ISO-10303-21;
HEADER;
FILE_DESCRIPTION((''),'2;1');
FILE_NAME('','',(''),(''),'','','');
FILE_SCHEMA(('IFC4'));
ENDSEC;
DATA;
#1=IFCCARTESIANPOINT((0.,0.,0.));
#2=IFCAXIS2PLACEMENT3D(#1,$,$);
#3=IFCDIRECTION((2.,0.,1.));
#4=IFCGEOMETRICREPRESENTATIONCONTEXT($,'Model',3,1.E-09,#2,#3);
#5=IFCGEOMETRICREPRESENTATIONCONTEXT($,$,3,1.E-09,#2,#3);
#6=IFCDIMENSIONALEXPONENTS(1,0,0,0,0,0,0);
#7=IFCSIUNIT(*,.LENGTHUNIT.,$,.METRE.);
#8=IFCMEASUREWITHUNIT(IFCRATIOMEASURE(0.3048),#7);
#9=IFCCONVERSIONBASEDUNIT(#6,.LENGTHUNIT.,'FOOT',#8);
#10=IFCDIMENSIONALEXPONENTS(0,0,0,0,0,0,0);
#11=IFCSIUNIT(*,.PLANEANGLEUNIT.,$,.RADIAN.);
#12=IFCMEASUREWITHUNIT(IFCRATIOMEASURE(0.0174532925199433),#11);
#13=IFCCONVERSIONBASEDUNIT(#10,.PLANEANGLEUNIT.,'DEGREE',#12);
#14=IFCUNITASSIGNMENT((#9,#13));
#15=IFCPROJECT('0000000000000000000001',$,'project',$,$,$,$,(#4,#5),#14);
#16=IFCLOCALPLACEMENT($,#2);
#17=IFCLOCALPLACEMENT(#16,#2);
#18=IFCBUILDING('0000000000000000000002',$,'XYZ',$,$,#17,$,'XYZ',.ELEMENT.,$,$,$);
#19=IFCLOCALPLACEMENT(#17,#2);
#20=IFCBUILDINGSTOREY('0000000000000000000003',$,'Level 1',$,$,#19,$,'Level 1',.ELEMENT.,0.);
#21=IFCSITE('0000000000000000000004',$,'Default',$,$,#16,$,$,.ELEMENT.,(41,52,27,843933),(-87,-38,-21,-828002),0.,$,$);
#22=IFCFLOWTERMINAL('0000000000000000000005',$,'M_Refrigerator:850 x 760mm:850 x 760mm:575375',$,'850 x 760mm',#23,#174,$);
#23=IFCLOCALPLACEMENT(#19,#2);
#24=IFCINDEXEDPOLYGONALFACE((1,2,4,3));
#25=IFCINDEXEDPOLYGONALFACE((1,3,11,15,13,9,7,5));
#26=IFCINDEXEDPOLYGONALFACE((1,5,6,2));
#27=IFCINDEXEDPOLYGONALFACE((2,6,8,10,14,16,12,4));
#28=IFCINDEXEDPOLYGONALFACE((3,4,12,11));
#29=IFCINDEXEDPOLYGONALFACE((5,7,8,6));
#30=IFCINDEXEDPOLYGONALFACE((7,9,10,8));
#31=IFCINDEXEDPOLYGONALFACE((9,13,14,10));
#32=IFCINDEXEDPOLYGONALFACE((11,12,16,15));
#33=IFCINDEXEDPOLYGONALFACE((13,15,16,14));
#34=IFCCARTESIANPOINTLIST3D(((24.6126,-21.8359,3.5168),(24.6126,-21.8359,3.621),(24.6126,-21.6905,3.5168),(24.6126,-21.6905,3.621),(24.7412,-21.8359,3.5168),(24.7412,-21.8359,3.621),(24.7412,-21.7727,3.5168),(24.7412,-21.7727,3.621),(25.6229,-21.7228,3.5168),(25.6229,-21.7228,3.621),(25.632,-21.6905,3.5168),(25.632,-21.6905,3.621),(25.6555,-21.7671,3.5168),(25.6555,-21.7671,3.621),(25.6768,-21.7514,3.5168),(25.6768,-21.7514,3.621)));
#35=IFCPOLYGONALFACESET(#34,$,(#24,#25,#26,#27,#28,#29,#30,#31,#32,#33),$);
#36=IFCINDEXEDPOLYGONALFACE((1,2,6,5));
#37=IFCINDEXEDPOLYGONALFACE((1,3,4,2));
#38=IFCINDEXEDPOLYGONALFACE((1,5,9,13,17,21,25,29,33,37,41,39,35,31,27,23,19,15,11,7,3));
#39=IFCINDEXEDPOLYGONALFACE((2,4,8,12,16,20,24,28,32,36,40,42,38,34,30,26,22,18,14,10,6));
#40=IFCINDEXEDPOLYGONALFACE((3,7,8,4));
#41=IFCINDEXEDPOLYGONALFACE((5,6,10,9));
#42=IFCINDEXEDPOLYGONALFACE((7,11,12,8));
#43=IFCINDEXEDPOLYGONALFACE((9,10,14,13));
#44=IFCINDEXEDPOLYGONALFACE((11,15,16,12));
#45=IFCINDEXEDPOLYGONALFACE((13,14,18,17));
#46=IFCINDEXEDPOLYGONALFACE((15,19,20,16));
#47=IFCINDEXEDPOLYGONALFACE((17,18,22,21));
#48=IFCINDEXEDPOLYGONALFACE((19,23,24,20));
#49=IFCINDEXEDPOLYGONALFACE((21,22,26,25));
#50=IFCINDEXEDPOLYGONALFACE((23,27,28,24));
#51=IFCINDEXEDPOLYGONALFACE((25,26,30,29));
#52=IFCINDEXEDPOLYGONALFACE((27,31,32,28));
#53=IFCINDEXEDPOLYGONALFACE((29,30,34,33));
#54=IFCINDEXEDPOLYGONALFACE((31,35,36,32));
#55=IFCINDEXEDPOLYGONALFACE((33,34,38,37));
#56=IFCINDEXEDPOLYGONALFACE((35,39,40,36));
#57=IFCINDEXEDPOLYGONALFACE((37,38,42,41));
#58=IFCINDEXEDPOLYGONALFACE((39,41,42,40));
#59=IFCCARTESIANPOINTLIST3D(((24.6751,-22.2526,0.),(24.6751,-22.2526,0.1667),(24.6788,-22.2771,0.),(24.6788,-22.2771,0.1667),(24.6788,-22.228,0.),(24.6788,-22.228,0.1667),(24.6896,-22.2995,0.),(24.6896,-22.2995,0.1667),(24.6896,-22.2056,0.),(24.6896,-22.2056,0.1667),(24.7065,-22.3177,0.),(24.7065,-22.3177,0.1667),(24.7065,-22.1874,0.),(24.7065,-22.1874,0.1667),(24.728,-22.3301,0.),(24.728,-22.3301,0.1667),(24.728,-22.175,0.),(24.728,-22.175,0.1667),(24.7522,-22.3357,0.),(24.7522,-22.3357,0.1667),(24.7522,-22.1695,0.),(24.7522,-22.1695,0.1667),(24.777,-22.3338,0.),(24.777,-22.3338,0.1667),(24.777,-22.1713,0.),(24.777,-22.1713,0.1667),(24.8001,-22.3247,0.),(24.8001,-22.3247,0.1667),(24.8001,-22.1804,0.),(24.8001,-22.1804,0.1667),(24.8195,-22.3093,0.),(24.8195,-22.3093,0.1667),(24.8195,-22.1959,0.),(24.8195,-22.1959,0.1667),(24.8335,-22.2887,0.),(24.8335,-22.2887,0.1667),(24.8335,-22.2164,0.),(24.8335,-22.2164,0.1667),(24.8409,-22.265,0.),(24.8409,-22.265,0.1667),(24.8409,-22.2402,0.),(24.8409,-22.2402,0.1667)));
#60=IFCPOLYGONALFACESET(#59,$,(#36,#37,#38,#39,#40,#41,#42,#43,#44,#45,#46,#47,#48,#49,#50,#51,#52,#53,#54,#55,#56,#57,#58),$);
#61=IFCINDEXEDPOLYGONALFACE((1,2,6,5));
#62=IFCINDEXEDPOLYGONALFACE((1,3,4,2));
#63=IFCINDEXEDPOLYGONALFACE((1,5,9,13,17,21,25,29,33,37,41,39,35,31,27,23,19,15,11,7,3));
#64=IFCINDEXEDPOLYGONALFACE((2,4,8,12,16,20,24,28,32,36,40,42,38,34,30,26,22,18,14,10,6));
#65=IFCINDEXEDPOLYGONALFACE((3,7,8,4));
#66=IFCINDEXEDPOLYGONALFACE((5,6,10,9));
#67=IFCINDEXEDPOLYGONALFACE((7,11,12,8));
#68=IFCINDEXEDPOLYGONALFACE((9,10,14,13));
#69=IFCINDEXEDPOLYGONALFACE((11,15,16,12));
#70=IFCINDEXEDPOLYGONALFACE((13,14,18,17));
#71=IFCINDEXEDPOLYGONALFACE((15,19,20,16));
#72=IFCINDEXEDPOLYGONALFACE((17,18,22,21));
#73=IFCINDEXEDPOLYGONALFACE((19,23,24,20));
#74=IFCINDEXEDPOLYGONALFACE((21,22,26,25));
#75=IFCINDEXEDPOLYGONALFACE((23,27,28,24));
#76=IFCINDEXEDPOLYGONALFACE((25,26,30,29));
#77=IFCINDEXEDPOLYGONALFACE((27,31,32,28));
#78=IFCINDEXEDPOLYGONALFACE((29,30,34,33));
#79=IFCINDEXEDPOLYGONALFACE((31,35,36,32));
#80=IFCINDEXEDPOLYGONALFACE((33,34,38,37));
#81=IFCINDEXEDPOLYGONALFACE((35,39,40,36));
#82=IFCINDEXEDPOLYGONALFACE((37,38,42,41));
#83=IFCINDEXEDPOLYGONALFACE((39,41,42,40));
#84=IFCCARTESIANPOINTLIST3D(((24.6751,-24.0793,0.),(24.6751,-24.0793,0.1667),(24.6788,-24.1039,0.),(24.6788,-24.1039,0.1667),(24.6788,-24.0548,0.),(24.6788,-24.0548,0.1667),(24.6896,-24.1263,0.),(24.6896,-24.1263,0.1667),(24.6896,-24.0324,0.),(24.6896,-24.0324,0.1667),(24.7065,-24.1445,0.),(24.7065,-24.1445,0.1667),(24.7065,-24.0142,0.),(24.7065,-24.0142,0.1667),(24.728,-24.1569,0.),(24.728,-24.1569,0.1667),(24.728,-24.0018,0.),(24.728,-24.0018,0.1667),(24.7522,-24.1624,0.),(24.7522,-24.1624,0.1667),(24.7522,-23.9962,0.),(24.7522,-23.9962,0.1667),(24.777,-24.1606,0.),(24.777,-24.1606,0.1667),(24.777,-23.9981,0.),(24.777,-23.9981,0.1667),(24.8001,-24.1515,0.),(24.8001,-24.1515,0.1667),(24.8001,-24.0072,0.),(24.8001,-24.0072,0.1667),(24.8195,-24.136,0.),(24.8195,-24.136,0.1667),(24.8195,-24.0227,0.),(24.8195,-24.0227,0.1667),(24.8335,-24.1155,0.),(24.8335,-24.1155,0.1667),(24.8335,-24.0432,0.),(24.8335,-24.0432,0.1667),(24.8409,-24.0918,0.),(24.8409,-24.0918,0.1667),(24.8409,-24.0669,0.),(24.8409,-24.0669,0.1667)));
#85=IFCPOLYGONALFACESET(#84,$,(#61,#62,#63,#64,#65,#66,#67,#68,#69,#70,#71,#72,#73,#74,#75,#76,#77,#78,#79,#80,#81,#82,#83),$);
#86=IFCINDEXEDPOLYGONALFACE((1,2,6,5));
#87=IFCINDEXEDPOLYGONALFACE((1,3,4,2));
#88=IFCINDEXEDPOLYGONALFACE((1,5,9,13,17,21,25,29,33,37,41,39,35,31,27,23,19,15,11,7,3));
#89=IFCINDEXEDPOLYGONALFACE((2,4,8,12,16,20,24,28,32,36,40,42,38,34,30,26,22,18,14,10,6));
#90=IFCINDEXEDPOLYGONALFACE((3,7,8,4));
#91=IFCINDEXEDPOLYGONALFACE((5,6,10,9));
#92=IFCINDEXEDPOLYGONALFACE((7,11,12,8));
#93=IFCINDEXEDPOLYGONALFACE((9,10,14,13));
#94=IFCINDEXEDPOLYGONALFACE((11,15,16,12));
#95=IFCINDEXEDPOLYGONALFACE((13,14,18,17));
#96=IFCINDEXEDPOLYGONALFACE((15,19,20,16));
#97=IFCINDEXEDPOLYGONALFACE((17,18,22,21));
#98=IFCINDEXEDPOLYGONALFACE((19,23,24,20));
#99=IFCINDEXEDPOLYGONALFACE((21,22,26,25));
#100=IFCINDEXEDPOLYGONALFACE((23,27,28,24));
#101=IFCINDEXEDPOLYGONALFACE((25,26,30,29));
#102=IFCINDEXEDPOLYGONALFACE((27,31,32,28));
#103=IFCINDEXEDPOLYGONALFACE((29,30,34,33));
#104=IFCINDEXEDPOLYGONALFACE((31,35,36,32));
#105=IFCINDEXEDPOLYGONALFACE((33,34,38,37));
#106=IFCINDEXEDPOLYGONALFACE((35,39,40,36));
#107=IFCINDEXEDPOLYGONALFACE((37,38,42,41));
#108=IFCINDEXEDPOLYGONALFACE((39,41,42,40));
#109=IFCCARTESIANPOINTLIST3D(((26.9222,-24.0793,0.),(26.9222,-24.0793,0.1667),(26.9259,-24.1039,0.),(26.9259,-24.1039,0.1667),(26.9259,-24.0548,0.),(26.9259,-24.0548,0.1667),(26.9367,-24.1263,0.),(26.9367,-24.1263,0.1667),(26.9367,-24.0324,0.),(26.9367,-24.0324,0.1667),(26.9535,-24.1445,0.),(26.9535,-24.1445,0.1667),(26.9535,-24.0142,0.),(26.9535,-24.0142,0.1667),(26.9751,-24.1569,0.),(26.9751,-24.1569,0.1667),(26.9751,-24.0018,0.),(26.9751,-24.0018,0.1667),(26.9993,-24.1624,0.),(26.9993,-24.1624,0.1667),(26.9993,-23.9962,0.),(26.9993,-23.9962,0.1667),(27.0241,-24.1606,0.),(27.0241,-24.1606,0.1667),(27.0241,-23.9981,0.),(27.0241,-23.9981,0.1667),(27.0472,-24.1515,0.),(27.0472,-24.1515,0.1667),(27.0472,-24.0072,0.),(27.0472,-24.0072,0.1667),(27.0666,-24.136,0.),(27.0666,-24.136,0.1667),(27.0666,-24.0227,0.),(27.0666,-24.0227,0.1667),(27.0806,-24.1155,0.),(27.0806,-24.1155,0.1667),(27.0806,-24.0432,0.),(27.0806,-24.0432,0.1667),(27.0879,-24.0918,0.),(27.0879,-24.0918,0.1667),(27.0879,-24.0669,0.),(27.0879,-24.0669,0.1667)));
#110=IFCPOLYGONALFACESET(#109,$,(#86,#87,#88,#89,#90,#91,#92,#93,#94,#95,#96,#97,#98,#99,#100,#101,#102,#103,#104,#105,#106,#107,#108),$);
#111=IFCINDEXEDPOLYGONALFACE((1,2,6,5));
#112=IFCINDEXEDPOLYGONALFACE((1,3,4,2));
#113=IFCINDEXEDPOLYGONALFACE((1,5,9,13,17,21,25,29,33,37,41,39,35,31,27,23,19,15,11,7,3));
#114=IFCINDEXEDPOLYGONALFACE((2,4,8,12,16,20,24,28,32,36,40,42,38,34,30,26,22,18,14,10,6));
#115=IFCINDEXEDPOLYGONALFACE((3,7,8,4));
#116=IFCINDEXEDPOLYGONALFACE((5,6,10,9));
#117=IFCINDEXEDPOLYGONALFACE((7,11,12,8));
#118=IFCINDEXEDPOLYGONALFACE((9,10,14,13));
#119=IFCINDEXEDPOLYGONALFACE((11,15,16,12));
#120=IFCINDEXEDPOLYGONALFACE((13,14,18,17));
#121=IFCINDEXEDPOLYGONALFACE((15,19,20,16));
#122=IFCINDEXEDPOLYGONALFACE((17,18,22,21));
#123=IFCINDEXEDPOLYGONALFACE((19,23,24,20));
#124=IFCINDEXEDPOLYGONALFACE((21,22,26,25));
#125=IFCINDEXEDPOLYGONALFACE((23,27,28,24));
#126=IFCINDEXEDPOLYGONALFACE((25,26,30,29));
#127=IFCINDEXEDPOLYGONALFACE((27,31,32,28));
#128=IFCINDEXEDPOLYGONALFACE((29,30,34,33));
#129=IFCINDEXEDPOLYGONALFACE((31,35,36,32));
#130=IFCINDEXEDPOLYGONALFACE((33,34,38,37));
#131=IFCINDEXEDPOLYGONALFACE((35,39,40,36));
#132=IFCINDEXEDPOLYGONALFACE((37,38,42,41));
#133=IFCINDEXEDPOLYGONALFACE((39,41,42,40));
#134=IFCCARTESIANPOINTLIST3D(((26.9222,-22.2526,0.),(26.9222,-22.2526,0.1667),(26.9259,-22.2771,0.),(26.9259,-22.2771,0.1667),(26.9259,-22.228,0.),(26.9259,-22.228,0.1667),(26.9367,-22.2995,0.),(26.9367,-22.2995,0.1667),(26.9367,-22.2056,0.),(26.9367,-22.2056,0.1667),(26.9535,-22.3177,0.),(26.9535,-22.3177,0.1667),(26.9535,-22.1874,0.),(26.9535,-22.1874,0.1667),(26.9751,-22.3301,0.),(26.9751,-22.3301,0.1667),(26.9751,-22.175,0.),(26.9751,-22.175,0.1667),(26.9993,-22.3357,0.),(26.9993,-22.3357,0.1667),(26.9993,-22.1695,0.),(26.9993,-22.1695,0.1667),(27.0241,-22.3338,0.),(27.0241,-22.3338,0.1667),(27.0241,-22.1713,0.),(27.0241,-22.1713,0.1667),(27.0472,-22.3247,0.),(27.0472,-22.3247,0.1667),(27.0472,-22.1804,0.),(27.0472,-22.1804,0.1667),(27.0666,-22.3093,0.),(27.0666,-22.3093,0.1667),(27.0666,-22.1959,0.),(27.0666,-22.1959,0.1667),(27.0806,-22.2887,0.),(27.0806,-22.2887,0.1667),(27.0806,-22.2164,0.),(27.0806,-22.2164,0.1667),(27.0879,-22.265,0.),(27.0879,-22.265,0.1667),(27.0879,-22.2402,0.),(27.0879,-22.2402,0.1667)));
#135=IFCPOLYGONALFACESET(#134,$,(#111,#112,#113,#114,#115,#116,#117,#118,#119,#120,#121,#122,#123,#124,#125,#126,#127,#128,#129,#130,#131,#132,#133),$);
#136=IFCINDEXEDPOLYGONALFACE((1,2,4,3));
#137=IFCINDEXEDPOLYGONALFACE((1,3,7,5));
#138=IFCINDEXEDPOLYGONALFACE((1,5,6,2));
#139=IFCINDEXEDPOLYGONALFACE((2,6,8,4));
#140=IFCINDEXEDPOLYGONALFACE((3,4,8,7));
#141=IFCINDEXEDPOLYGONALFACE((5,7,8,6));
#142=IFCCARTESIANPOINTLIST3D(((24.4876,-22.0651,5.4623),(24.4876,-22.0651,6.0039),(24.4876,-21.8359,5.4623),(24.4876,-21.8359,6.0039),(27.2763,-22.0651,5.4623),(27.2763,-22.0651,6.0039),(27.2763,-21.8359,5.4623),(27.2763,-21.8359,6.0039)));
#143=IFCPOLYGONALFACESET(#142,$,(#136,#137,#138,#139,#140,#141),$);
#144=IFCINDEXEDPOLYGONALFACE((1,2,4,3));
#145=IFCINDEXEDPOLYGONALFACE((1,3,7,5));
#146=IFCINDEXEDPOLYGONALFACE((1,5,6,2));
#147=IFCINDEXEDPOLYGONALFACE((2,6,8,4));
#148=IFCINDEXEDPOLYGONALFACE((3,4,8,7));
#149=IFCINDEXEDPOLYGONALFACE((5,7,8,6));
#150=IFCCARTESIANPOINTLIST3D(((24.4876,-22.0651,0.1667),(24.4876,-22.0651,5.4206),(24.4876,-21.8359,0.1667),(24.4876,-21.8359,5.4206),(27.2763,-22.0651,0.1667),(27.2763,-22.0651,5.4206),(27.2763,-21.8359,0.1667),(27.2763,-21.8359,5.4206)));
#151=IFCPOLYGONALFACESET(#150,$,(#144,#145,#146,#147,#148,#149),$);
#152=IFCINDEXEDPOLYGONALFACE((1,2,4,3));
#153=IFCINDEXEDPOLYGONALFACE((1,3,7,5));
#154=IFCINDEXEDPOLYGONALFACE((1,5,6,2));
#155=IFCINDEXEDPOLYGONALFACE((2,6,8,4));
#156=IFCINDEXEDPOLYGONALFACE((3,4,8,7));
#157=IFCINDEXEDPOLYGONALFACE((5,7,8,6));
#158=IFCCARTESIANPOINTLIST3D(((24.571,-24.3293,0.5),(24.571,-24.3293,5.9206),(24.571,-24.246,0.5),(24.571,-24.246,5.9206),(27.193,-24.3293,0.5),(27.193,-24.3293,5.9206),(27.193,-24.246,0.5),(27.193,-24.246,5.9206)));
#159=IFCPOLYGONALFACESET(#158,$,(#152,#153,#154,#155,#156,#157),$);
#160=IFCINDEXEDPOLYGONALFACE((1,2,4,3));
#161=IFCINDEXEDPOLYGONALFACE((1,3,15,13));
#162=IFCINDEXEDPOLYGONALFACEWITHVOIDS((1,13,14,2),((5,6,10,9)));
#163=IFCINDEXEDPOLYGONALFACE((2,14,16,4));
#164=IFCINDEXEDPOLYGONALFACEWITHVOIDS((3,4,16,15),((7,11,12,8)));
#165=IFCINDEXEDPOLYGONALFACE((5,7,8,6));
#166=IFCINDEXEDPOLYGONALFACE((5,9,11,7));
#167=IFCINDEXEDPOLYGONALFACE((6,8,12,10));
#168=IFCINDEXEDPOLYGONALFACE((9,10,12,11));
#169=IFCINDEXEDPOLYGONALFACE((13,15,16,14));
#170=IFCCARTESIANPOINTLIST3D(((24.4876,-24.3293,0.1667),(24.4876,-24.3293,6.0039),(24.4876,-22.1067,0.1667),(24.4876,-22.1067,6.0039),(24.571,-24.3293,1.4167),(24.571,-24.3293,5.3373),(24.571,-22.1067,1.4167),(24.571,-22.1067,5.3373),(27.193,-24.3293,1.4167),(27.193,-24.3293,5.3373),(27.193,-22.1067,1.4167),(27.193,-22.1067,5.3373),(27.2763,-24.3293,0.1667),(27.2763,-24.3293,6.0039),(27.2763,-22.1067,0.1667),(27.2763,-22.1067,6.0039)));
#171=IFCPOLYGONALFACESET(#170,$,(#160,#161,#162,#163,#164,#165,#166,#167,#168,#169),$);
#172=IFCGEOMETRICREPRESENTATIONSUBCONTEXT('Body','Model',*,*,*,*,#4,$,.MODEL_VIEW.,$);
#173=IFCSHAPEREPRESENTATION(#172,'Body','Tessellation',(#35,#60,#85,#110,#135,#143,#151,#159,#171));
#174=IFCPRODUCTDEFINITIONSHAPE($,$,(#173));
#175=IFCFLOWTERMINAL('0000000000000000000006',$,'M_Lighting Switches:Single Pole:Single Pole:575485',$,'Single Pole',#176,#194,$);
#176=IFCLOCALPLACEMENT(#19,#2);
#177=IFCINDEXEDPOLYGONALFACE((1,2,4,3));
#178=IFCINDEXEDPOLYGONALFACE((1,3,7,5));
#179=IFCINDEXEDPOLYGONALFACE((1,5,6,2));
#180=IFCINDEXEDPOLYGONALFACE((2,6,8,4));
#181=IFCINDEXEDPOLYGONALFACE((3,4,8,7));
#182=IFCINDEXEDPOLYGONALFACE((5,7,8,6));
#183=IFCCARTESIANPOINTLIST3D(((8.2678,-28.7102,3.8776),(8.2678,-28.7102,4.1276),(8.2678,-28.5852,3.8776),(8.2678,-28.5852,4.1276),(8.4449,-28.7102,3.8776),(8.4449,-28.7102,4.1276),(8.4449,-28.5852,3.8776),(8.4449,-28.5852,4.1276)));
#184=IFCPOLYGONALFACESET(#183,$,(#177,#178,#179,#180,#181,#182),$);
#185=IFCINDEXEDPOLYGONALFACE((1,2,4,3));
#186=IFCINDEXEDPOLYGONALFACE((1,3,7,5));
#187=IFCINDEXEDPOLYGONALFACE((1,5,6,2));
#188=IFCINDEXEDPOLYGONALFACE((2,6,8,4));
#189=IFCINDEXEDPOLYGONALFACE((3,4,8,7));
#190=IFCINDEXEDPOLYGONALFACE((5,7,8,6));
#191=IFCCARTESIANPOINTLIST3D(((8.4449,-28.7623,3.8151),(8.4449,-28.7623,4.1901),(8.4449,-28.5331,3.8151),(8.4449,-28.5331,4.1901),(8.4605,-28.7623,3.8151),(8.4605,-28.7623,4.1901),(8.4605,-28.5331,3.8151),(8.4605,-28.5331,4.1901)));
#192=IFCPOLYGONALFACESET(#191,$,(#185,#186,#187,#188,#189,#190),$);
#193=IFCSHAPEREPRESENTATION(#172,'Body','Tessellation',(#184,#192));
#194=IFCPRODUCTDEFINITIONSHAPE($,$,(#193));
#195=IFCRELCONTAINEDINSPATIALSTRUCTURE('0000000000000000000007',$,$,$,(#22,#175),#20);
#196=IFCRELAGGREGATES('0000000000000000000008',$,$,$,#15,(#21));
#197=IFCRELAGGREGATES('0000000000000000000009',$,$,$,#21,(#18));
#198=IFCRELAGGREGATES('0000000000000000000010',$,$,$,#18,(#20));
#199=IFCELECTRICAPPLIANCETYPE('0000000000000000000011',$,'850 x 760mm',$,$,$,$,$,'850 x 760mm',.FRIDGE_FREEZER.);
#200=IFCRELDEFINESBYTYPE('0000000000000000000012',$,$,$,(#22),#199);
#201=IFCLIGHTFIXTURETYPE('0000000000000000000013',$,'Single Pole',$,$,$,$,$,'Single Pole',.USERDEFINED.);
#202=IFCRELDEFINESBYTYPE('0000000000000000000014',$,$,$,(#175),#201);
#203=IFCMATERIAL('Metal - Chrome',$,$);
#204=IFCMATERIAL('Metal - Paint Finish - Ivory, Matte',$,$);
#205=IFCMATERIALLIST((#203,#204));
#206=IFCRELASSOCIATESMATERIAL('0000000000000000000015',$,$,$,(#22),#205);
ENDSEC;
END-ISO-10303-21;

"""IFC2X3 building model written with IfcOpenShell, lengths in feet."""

from ifc_helpers import new_model, entity, si_unit, converted_unit, direction, frame, frame_2d, origin, origin_2d_with_axis, place, context, subcontext, project, spatial, polyline, rectangle, circle, outline, extrude, source, transform, mapped, material, material_list, type_object, type_shapes, element, save


model = new_model("IFC2X3")

# Units and contexts
model_context = context("Model", 3, precision=1e-09, world=origin(), true_north=direction((2.0, 0.0, 1.0)))
context_of_model = context(None, 3, precision=1e-09, world=origin(), true_north=direction((2.0, 0.0, 1.0)))
body_context = subcontext(model_context, "Body", "Model", "MODEL_VIEW")
ifc_project = project(units=[converted_unit("LENGTHUNIT", "FOOT", entity("IfcRatioMeasure", 0.3048), si_unit("LENGTHUNIT", "METRE"), dimensions=[1, 0, 0, 0, 0, 0, 0]), converted_unit("PLANEANGLEUNIT", "DEGREE", entity("IfcRatioMeasure", 0.0174532925199433), si_unit("PLANEANGLEUNIT", "RADIAN"), dimensions=[0, 0, 0, 0, 0, 0, 0])], contexts=[model_context, context_of_model])

# Site, building, storey
site_placement = place(None, origin())
site = spatial("IfcSite", under=ifc_project, at=site_placement, Name="Default", CompositionType="ELEMENT", RefLatitude=(41, 52, 27, 843933), RefLongitude=(-87, -38, -21, -828002), RefElevation=0.0)
building_placement = place(site_placement, origin())
building = spatial("IfcBuilding", under=site, at=building_placement, Name="XYZ", LongName="XYZ", CompositionType="ELEMENT")
storey_placement = place(building_placement, origin())
storey = spatial("IfcBuildingStorey", under=building, at=storey_placement, Name="Level 1", LongName="Level 1", CompositionType="ELEMENT", Elevation=0.0)

# Flow terminals
ifc_material_1 = material(Name="Metal - Chrome")
ifc_material_2 = material(Name="Metal - Paint Finish - Ivory, Matte")
ifc_material_list = material_list([ifc_material_1, ifc_material_2])
electric_appliance_type_1 = type_object("IfcElectricApplianceType", Name="850 x 760mm", ElementType="850 x 760mm", PredefinedType="FRIDGE_FREEZER")
shared_shape_1 = source(origin(), body_context, "Body", "SweptSolid", [
    extrude(outline(polyline([(-0.0679, -0.5492), (0.0775, -0.5492), (0.0775, -0.4207), (0.0144, -0.4207), (-0.0355, 0.461), (0.0088, 0.4937), (-0.0069, 0.515), (-0.0679, 0.4701), (-0.0679, -0.5492)])), frame((0.5436, -1.4351, 3.5168), z_axis=(0.0, 0.0, 1.0), x_axis=(0.0, 1.0, 0.0)), (0.0, 0.0, 1.0), 0.1042),
    extrude(circle(Radius=0.0833, at=frame_2d((0.0, 0.0), x_axis=(1.0, 0.0))), frame((0.947, -0.9409, 0.0)), (0.0, 0.0, 1.0), 0.1667),
    extrude(circle(Radius=0.0833, at=frame_2d((0.0, 0.0), x_axis=(1.0, 0.0))), frame((0.947, 0.8859, 0.0)), (0.0, 0.0, 1.0), 0.1667),
    extrude(circle(Radius=0.0833, at=frame_2d((0.0, 0.0), x_axis=(1.0, 0.0))), frame((-1.3, 0.8859, 0.0)), (0.0, 0.0, 1.0), 0.1667),
    extrude(circle(Radius=0.0833, at=frame_2d((0.0, 0.0), x_axis=(1.0, 0.0))), frame((-1.3, -0.9409, 0.0)), (0.0, 0.0, 1.0), 0.1667),
    extrude(rectangle(XDim=0.2292, YDim=2.7887, at=frame_2d((0.0, 0.0), x_axis=(1.0, 0.0))), frame((-0.1765, -1.243, 5.4623), z_axis=(0.0, 0.0, 1.0), x_axis=(0.0, 1.0, 0.0)), (0.0, 0.0, 1.0), 0.5417),
    extrude(rectangle(XDim=0.2292, YDim=2.7887, at=frame_2d((0.0, 0.0), x_axis=(1.0, 0.0))), frame((-0.1765, -1.243, 0.1667), z_axis=(0.0, 0.0, 1.0), x_axis=(0.0, 1.0, 0.0)), (0.0, 0.0, 1.0), 5.2539),
    extrude(rectangle(XDim=0.0833, YDim=2.622, at=frame_2d((0.0, 0.0), x_axis=(1.0, 0.0))), frame((-0.1765, 1.0942, 0.5), z_axis=(0.0, 0.0, 1.0), x_axis=(0.0, 1.0, 0.0)), (0.0, 0.0, 1.0), 5.4206),
    extrude(outline(polyline([(-2.9186, -1.3944), (2.9186, -1.3944), (2.9186, 1.3944), (-2.9186, 1.3944), (-2.9186, -1.3944)]), holes=[polyline([(-2.252, -1.311), (-2.252, 1.311), (1.6686, 1.311), (1.6686, -1.311), (-2.252, -1.311)])]), frame((-0.1765, -1.0867, 3.0853), z_axis=(0.0, 1.0, 0.0), x_axis=(0.0, 0.0, -1.0)), (0.0, 0.0, 1.0), 2.2226),
])
type_shapes(electric_appliance_type_1, [shared_shape_1])
flow_terminal_1_placement = place(storey_placement, frame((25.7055, -23.1935, 0.0), z_axis=(0.0, 0.0, 1.0), x_axis=(-1.0, 0.0, 0.0)))
element("IfcFlowTerminal", 1, at=flow_terminal_1_placement, inside=storey, type_object=electric_appliance_type_1, material=ifc_material_list, Name="M_Refrigerator:850 x 760mm:850 x 760mm:575375", ObjectType="850 x 760mm", context=body_context, shape_type="MappedRepresentation", body=[
    mapped(shared_shape_1, transform((0.0, 0.0, 0.0), scale=1.0)),
])
light_fixture_type = type_object("IfcLightFixtureType", Name="Single Pole", ElementType="Single Pole", PredefinedType="USERDEFINED")
shared_shape_2 = source(origin(), body_context, "Body", "SweptSolid", [
    extrude(rectangle(XDim=0.125, YDim=0.25, at=origin_2d_with_axis()), frame((0.0, 0.0, -0.1771), z_axis=(0.0, 0.0, 1.0), x_axis=(-1.0, 0.0, 0.0)), (0.0, 0.0, 1.0), 0.1771),
    extrude(rectangle(XDim=0.2292, YDim=0.375, at=frame_2d((0.0, 0.0), x_axis=(1.0, 0.0))), frame((0.0, 0.0, 0.0), z_axis=(0.0, 0.0, 1.0), x_axis=(-1.0, 0.0, 0.0)), (0.0, 0.0, 1.0), 0.0156),
])
type_shapes(light_fixture_type, [shared_shape_2])
for number, where, z_axis, x_axis, name in (
    (2, (8.4449, -28.6477, 4.0026), (1.0, 0.0, 0.0), (0.0, 1.0, 0.0), "M_Lighting Switches:Single Pole:Single Pole:575485"),
):
    element("IfcFlowTerminal", number, at=place(storey_placement, frame(where, z_axis=z_axis, x_axis=x_axis)), inside=storey, type_object=light_fixture_type, Name=name, ObjectType="Single Pole", context=body_context, shape_type="MappedRepresentation", body=[
        mapped(shared_shape_2, transform((0.0, 0.0, 0.0), scale=1.0)),
    ])

save(model, "model.ifc")
